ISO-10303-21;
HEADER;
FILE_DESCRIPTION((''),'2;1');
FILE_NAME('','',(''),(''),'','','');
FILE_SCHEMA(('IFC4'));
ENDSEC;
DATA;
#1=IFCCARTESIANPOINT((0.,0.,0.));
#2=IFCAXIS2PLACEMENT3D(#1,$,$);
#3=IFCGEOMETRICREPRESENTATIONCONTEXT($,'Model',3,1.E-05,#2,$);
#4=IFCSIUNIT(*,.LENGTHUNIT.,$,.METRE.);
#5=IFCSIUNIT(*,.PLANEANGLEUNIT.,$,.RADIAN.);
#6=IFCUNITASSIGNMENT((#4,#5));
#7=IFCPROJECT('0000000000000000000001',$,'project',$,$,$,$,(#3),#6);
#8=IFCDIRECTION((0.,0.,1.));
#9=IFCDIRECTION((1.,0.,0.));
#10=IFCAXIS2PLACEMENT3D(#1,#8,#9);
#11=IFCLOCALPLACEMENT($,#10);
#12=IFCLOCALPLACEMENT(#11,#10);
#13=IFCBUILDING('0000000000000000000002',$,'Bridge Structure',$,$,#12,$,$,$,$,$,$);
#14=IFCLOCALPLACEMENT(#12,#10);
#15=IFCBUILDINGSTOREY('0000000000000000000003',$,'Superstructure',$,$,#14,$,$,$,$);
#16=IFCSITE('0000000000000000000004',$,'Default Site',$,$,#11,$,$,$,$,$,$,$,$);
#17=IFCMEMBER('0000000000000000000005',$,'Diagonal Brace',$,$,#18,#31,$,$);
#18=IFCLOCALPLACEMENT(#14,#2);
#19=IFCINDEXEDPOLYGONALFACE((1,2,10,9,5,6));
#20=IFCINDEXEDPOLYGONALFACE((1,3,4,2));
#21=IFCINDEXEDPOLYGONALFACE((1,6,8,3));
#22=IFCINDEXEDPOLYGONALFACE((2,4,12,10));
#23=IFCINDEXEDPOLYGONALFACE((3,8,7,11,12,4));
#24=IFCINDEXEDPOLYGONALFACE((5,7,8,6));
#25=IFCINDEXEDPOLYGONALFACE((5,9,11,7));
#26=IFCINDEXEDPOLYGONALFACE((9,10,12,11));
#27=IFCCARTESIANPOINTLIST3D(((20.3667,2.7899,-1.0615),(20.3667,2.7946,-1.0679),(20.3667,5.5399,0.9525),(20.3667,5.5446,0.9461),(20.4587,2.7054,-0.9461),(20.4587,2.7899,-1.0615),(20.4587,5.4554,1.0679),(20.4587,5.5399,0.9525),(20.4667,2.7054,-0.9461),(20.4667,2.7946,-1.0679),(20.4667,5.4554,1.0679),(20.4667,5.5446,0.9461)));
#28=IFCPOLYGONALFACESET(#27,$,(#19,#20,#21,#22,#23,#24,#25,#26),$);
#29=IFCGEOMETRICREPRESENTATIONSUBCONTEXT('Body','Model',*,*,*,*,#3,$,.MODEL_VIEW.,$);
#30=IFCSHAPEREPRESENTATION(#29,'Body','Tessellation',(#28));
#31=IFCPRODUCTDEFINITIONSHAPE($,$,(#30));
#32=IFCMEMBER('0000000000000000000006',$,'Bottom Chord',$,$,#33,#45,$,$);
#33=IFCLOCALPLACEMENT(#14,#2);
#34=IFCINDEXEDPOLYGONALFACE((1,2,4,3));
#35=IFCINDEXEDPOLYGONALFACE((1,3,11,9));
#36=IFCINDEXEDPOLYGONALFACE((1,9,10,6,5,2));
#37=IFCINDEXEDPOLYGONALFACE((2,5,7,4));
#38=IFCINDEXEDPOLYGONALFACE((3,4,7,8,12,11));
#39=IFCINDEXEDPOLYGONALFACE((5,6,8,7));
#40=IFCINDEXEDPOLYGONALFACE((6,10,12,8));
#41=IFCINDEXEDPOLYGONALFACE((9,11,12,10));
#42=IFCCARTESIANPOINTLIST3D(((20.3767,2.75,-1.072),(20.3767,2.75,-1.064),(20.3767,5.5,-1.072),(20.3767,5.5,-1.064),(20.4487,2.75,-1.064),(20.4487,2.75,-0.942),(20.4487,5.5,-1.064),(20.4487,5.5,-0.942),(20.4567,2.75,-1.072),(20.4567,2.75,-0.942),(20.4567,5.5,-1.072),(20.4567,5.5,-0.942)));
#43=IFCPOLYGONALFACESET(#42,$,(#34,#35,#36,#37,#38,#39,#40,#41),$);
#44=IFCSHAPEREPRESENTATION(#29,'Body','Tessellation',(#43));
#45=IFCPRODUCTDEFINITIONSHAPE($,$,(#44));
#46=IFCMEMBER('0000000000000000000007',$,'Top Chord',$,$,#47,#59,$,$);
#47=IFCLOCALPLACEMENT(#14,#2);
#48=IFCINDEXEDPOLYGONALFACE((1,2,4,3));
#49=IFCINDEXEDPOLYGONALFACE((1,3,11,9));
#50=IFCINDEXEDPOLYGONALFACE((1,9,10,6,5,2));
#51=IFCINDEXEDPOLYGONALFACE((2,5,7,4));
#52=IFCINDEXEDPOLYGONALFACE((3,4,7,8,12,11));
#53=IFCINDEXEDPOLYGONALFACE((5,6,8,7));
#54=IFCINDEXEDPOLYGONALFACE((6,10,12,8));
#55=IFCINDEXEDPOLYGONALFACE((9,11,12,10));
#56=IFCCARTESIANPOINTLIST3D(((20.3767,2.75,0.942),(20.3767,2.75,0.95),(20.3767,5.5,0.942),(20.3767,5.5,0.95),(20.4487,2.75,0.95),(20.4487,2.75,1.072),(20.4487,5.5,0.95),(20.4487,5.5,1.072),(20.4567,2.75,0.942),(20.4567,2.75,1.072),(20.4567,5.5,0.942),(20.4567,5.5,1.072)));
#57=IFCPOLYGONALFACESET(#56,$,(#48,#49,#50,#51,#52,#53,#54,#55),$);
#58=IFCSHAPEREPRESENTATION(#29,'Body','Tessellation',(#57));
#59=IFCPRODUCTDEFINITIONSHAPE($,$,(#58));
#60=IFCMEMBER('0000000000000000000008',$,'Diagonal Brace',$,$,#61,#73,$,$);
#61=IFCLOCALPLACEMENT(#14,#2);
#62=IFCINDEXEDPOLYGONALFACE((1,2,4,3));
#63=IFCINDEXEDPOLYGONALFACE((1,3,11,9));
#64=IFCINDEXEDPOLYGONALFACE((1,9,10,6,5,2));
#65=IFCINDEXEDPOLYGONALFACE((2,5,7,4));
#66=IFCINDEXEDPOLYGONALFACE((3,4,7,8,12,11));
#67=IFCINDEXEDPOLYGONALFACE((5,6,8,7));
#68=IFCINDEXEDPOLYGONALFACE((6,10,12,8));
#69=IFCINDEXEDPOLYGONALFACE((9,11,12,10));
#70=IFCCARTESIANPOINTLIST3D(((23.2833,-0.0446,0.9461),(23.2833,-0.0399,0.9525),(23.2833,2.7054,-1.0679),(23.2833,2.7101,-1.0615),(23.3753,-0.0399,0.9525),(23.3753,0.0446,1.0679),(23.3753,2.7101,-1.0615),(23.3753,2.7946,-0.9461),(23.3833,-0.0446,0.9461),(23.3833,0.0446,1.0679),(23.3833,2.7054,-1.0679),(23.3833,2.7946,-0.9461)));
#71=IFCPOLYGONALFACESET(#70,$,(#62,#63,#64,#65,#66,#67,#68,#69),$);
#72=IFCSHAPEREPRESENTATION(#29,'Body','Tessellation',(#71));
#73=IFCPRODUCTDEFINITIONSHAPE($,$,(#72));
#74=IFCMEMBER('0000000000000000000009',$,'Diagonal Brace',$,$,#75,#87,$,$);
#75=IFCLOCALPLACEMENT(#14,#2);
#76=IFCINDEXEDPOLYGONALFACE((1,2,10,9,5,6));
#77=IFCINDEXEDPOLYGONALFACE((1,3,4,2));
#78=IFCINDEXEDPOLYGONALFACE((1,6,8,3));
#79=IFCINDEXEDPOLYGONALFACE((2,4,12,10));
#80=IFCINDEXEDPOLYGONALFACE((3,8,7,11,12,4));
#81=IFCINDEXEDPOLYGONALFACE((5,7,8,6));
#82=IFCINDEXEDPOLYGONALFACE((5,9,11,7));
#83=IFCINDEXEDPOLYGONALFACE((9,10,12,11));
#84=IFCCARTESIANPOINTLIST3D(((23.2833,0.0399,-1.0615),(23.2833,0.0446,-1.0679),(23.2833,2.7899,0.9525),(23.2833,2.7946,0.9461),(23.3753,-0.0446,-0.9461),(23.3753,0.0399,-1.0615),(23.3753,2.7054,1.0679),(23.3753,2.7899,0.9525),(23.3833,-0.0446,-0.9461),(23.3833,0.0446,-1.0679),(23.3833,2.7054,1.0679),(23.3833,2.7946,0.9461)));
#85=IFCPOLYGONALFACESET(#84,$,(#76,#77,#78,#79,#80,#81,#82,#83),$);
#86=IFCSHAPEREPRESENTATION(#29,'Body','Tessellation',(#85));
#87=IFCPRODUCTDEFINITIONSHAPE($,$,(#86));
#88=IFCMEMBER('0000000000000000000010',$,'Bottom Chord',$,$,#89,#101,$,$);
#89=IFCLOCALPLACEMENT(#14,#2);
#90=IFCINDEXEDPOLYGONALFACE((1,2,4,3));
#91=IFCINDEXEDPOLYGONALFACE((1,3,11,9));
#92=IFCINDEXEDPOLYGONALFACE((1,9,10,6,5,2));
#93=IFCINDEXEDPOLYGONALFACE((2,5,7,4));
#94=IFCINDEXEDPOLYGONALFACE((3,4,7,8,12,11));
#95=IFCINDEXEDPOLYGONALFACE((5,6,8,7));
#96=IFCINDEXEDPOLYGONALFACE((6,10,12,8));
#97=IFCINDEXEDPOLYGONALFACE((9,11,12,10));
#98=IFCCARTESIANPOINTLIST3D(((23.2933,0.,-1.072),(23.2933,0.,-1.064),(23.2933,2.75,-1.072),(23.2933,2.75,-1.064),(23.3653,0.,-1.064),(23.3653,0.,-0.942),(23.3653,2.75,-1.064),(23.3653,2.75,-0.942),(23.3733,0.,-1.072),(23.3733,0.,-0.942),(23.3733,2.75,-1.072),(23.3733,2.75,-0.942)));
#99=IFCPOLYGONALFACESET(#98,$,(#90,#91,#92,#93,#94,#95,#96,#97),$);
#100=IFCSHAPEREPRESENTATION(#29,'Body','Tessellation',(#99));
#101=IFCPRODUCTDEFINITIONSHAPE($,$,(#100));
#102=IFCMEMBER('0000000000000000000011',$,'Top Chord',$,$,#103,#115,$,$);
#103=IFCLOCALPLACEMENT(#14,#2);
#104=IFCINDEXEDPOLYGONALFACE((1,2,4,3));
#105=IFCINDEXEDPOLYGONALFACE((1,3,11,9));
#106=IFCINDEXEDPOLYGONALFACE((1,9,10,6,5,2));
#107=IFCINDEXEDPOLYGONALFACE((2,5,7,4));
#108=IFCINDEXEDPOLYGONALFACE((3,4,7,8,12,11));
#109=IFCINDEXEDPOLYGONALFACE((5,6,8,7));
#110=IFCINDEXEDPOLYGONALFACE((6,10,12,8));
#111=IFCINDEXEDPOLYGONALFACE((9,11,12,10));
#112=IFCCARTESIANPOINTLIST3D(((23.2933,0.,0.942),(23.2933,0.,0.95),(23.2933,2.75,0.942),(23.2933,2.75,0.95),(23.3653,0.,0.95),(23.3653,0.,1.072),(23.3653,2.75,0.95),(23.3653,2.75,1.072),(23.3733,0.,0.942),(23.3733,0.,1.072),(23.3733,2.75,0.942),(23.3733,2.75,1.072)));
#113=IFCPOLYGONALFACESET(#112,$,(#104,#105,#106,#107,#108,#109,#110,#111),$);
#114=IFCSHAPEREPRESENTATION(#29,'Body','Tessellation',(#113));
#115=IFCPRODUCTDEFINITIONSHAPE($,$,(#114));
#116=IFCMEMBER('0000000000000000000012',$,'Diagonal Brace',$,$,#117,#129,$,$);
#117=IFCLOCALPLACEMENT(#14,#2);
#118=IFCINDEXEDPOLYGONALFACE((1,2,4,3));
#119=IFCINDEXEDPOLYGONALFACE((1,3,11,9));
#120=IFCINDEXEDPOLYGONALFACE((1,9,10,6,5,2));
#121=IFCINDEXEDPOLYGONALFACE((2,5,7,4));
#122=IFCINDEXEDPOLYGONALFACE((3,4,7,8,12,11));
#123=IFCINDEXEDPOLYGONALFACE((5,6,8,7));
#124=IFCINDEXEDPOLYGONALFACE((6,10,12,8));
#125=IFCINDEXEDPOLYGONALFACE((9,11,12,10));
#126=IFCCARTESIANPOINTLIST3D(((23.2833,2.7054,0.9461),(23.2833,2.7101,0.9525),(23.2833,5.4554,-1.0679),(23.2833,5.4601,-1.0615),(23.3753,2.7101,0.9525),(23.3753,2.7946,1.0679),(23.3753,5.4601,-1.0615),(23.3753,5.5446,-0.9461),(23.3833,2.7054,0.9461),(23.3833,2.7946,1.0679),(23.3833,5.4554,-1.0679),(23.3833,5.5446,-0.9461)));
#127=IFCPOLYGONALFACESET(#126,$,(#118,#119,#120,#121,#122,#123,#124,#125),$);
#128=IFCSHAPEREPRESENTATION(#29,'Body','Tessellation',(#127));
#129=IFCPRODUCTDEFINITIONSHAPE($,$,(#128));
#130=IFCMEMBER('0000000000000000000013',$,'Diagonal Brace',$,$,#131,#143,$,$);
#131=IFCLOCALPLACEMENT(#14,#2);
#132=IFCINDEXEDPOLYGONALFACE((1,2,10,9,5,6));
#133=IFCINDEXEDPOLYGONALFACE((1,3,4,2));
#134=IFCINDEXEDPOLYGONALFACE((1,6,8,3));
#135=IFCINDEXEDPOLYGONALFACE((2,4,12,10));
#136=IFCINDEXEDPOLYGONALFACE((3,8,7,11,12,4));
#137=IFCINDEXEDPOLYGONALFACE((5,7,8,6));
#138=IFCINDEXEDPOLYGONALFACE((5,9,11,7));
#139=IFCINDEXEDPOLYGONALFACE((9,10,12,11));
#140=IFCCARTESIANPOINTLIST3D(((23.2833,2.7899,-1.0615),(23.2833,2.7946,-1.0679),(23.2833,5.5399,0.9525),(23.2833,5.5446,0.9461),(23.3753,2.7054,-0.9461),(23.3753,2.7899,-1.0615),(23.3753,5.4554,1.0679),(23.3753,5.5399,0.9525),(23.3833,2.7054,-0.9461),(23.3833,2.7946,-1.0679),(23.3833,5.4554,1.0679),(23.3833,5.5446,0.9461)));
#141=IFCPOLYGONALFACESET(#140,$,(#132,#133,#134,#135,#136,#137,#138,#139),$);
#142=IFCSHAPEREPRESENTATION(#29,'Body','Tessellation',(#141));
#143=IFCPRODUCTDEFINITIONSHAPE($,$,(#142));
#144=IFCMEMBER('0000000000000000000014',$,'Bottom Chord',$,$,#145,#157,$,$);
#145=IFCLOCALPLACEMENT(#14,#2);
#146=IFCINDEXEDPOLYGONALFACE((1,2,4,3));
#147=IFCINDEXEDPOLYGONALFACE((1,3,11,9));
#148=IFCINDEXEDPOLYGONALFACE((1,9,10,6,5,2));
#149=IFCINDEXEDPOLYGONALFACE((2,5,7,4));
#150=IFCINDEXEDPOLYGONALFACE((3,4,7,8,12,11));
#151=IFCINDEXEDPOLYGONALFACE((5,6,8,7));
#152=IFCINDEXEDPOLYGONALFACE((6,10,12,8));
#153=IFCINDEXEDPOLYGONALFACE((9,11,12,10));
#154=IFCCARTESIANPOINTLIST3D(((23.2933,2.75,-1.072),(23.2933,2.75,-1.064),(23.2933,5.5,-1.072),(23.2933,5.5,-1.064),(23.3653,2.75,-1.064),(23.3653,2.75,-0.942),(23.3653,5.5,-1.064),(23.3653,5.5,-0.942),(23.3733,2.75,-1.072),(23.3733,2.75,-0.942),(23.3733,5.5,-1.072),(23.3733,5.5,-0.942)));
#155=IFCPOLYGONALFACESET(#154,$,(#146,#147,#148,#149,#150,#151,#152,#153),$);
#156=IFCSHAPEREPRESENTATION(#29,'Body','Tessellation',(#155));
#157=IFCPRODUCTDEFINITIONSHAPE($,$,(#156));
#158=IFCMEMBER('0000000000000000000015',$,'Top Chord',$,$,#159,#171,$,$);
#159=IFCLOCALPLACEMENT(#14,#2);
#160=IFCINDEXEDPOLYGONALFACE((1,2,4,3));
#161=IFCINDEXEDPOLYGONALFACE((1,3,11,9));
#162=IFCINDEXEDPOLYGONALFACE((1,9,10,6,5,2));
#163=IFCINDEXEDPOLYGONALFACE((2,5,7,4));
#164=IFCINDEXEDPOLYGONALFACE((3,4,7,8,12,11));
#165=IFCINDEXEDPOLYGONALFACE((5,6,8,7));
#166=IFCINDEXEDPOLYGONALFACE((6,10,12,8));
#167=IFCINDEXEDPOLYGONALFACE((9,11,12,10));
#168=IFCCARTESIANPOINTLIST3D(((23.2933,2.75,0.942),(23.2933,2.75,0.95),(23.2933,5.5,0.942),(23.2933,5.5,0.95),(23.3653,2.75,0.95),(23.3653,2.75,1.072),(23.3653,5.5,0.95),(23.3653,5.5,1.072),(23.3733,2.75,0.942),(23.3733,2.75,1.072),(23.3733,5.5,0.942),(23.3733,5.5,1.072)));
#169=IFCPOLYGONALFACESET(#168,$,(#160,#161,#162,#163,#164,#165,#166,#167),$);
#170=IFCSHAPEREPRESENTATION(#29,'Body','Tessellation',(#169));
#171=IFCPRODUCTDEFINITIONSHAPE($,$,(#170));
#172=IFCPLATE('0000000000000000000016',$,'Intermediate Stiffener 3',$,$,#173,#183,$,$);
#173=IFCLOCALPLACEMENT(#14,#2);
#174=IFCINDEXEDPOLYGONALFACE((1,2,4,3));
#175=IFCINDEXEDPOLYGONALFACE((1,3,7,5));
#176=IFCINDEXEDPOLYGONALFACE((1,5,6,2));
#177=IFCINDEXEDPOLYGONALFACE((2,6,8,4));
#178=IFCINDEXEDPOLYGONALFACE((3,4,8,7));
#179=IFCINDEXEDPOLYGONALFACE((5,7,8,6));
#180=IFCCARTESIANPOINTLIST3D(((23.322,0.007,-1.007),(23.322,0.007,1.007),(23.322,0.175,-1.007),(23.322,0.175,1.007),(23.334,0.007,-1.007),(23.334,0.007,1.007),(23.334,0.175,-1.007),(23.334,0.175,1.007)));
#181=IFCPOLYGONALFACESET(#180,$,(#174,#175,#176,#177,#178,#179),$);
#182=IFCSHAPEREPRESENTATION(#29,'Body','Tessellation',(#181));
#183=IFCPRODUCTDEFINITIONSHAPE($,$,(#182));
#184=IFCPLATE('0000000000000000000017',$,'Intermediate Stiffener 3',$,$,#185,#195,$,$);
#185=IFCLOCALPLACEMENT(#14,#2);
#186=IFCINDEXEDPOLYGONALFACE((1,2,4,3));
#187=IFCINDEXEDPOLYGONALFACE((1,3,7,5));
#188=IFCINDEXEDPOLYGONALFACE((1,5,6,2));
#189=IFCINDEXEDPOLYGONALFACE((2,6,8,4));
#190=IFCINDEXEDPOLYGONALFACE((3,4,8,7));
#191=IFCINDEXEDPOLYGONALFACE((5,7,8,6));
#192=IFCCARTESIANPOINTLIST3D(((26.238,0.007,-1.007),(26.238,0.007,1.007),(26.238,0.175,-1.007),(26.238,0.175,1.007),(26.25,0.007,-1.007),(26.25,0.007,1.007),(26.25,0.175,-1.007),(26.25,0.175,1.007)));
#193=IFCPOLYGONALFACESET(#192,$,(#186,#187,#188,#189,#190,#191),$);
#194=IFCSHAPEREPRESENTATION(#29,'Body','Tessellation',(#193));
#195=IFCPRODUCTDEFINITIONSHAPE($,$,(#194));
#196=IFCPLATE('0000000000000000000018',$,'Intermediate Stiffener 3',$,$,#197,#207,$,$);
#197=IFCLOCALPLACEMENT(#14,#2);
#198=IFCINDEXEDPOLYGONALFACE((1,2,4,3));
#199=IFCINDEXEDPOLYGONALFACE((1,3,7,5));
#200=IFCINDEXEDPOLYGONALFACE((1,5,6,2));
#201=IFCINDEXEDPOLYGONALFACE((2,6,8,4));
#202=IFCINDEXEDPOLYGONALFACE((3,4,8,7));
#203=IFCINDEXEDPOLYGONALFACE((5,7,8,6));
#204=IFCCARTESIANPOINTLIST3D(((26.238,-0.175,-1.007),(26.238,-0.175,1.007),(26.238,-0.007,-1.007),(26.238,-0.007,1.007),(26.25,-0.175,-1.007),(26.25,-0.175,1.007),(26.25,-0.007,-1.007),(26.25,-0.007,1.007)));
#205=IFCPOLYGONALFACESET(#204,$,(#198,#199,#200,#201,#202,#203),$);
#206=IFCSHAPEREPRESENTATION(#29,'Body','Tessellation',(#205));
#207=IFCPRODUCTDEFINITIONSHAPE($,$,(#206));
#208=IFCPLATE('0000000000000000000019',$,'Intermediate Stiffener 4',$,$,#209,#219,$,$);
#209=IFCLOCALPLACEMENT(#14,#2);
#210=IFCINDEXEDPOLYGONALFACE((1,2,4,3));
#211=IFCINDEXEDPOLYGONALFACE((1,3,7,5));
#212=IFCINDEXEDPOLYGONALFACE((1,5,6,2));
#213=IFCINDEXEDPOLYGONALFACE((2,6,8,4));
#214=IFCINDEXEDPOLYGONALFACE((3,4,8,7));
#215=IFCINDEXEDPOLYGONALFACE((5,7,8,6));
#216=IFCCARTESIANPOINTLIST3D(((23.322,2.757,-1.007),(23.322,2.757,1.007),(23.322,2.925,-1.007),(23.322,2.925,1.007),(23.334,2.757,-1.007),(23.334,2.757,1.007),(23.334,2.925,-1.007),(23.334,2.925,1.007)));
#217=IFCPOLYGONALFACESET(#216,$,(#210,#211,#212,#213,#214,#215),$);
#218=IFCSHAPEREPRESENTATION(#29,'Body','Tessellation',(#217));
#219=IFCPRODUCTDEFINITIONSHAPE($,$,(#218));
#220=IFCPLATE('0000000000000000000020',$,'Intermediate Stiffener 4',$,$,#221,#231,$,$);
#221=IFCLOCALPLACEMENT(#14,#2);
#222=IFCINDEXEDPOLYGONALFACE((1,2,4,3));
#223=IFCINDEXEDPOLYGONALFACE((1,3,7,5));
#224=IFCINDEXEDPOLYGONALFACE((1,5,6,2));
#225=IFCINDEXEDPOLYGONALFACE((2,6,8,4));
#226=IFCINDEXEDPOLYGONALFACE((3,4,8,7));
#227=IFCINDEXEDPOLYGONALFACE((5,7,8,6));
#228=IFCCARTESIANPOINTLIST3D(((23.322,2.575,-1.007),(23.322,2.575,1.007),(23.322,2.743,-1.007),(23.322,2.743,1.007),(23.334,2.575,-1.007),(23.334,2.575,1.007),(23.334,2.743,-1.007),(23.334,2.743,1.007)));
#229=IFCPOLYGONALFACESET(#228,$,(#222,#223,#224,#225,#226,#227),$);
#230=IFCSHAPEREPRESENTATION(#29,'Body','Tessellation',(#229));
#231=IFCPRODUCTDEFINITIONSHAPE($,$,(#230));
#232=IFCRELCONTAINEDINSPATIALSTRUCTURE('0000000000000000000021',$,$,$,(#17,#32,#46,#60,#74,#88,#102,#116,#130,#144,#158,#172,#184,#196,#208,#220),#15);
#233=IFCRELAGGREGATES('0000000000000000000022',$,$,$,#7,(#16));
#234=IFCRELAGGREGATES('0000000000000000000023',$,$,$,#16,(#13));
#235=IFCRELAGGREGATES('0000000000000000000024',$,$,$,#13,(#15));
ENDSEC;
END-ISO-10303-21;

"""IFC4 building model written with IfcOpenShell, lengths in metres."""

from ifc_helpers import new_model, si_unit, frame, origin, origin_with_axes, origin_2d_with_axis, place, context, subcontext, project, spatial, rectangle, l_section, extrude, element, save


model = new_model("IFC4")

# Units and contexts
model_context = context("Model", 3, precision=1e-05, world=origin())
body_context = subcontext(model_context, "Body", "Model", "MODEL_VIEW")
ifc_project = project(units=[si_unit("LENGTHUNIT", "METRE"), si_unit("PLANEANGLEUNIT", "RADIAN")], contexts=[model_context])

# Site, building, storey
site_placement = place(None, origin_with_axes())
site = spatial("IfcSite", under=ifc_project, at=site_placement, Name="Default Site")
building_placement = place(site_placement, origin_with_axes())
building = spatial("IfcBuilding", under=site, at=building_placement, Name="Bridge Structure")
storey_placement = place(building_placement, origin_with_axes())
storey = spatial("IfcBuildingStorey", under=building, at=storey_placement, Name="Superstructure")

# Members
member_placement = place(storey_placement, frame((20.4167, 2.75, -1.007), z_axis=(0.0, 0.806778, 0.590855), x_axis=(-1.0, 0.0, 0.0)))
element("IfcMember", 1, at=member_placement, inside=storey, Name="Diagonal Brace", context=body_context, shape_type="SweptSolid", body=[
    extrude(l_section(Depth=0.151, Width=0.1, Thickness=0.008, at=origin_2d_with_axis()), origin_with_axes(), (0.0, 0.0, 1.0), 3.4086),
])
for number, where, z_axis, x_axis, name in (
    (2, (20.4167, 2.75, -1.007), (0.0, 1.0, 0.0), (-1.0, 0.0, 0.0), "Bottom Chord"),
    (3, (20.4167, 2.75, 1.007), (0.0, 1.0, 0.0), (-1.0, 0.0, 0.0), "Top Chord"),
):
    element("IfcMember", number, at=place(storey_placement, frame(where, z_axis=z_axis, x_axis=x_axis)), inside=storey, Name=name, context=body_context, shape_type="SweptSolid", body=[
        extrude(l_section(Depth=0.13, Width=0.08, Thickness=0.008, at=origin_2d_with_axis()), origin_with_axes(), (0.0, 0.0, 1.0), 2.75),
    ])
for number, where, z_axis, x_axis, name in (
    (4, (23.3333, 0.0, 1.007), (0.0, 0.806778, -0.590855), (-1.0, 0.0, 0.0), "Diagonal Brace"),
    (5, (23.3333, 0.0, -1.007), (0.0, 0.806778, 0.590855), (-1.0, 0.0, 0.0), "Diagonal Brace"),
):
    element("IfcMember", number, at=place(storey_placement, frame(where, z_axis=z_axis, x_axis=x_axis)), inside=storey, Name=name, context=body_context, shape_type="SweptSolid", body=[
        extrude(l_section(Depth=0.151, Width=0.1, Thickness=0.008, at=origin_2d_with_axis()), origin_with_axes(), (0.0, 0.0, 1.0), 3.4086),
    ])
for number, where, z_axis, x_axis, name in (
    (6, (23.3333, 0.0, -1.007), (0.0, 1.0, 0.0), (-1.0, 0.0, 0.0), "Bottom Chord"),
    (7, (23.3333, 0.0, 1.007), (0.0, 1.0, 0.0), (-1.0, 0.0, 0.0), "Top Chord"),
):
    element("IfcMember", number, at=place(storey_placement, frame(where, z_axis=z_axis, x_axis=x_axis)), inside=storey, Name=name, context=body_context, shape_type="SweptSolid", body=[
        extrude(l_section(Depth=0.13, Width=0.08, Thickness=0.008, at=origin_2d_with_axis()), origin_with_axes(), (0.0, 0.0, 1.0), 2.75),
    ])
for number, where, z_axis, x_axis, name in (
    (8, (23.3333, 2.75, 1.007), (0.0, 0.806778, -0.590855), (-1.0, 0.0, 0.0), "Diagonal Brace"),
    (9, (23.3333, 2.75, -1.007), (0.0, 0.806778, 0.590855), (-1.0, 0.0, 0.0), "Diagonal Brace"),
):
    element("IfcMember", number, at=place(storey_placement, frame(where, z_axis=z_axis, x_axis=x_axis)), inside=storey, Name=name, context=body_context, shape_type="SweptSolid", body=[
        extrude(l_section(Depth=0.151, Width=0.1, Thickness=0.008, at=origin_2d_with_axis()), origin_with_axes(), (0.0, 0.0, 1.0), 3.4086),
    ])
for number, where, z_axis, x_axis, name in (
    (10, (23.3333, 2.75, -1.007), (0.0, 1.0, 0.0), (-1.0, 0.0, 0.0), "Bottom Chord"),
    (11, (23.3333, 2.75, 1.007), (0.0, 1.0, 0.0), (-1.0, 0.0, 0.0), "Top Chord"),
):
    element("IfcMember", number, at=place(storey_placement, frame(where, z_axis=z_axis, x_axis=x_axis)), inside=storey, Name=name, context=body_context, shape_type="SweptSolid", body=[
        extrude(l_section(Depth=0.13, Width=0.08, Thickness=0.008, at=origin_2d_with_axis()), origin_with_axes(), (0.0, 0.0, 1.0), 2.75),
    ])

# Plates
for number, where, z_axis, x_axis, name in (
    (12, (23.328, 0.091, -1.007), (0.0, 0.0, 1.0), (1.0, 0.0, 0.0), "Intermediate Stiffener 3"),
    (13, (26.244, 0.091, -1.007), (0.0, 0.0, 1.0), (1.0, 0.0, 0.0), "Intermediate Stiffener 3"),
    (14, (26.244, -0.091, -1.007), (0.0, 0.0, 1.0), (1.0, 0.0, 0.0), "Intermediate Stiffener 3"),
    (15, (23.328, 2.841, -1.007), (0.0, 0.0, 1.0), (1.0, 0.0, 0.0), "Intermediate Stiffener 4"),
    (16, (23.328, 2.659, -1.007), (0.0, 0.0, 1.0), (1.0, 0.0, 0.0), "Intermediate Stiffener 4"),
):
    element("IfcPlate", number, at=place(storey_placement, frame(where, z_axis=z_axis, x_axis=x_axis)), inside=storey, Name=name, context=body_context, shape_type="SweptSolid", body=[
        extrude(rectangle(XDim=0.012, YDim=0.168, at=origin_2d_with_axis()), origin_with_axes(), (0.0, 0.0, 1.0), 2.014),
    ])

save(model, "model.ifc")
